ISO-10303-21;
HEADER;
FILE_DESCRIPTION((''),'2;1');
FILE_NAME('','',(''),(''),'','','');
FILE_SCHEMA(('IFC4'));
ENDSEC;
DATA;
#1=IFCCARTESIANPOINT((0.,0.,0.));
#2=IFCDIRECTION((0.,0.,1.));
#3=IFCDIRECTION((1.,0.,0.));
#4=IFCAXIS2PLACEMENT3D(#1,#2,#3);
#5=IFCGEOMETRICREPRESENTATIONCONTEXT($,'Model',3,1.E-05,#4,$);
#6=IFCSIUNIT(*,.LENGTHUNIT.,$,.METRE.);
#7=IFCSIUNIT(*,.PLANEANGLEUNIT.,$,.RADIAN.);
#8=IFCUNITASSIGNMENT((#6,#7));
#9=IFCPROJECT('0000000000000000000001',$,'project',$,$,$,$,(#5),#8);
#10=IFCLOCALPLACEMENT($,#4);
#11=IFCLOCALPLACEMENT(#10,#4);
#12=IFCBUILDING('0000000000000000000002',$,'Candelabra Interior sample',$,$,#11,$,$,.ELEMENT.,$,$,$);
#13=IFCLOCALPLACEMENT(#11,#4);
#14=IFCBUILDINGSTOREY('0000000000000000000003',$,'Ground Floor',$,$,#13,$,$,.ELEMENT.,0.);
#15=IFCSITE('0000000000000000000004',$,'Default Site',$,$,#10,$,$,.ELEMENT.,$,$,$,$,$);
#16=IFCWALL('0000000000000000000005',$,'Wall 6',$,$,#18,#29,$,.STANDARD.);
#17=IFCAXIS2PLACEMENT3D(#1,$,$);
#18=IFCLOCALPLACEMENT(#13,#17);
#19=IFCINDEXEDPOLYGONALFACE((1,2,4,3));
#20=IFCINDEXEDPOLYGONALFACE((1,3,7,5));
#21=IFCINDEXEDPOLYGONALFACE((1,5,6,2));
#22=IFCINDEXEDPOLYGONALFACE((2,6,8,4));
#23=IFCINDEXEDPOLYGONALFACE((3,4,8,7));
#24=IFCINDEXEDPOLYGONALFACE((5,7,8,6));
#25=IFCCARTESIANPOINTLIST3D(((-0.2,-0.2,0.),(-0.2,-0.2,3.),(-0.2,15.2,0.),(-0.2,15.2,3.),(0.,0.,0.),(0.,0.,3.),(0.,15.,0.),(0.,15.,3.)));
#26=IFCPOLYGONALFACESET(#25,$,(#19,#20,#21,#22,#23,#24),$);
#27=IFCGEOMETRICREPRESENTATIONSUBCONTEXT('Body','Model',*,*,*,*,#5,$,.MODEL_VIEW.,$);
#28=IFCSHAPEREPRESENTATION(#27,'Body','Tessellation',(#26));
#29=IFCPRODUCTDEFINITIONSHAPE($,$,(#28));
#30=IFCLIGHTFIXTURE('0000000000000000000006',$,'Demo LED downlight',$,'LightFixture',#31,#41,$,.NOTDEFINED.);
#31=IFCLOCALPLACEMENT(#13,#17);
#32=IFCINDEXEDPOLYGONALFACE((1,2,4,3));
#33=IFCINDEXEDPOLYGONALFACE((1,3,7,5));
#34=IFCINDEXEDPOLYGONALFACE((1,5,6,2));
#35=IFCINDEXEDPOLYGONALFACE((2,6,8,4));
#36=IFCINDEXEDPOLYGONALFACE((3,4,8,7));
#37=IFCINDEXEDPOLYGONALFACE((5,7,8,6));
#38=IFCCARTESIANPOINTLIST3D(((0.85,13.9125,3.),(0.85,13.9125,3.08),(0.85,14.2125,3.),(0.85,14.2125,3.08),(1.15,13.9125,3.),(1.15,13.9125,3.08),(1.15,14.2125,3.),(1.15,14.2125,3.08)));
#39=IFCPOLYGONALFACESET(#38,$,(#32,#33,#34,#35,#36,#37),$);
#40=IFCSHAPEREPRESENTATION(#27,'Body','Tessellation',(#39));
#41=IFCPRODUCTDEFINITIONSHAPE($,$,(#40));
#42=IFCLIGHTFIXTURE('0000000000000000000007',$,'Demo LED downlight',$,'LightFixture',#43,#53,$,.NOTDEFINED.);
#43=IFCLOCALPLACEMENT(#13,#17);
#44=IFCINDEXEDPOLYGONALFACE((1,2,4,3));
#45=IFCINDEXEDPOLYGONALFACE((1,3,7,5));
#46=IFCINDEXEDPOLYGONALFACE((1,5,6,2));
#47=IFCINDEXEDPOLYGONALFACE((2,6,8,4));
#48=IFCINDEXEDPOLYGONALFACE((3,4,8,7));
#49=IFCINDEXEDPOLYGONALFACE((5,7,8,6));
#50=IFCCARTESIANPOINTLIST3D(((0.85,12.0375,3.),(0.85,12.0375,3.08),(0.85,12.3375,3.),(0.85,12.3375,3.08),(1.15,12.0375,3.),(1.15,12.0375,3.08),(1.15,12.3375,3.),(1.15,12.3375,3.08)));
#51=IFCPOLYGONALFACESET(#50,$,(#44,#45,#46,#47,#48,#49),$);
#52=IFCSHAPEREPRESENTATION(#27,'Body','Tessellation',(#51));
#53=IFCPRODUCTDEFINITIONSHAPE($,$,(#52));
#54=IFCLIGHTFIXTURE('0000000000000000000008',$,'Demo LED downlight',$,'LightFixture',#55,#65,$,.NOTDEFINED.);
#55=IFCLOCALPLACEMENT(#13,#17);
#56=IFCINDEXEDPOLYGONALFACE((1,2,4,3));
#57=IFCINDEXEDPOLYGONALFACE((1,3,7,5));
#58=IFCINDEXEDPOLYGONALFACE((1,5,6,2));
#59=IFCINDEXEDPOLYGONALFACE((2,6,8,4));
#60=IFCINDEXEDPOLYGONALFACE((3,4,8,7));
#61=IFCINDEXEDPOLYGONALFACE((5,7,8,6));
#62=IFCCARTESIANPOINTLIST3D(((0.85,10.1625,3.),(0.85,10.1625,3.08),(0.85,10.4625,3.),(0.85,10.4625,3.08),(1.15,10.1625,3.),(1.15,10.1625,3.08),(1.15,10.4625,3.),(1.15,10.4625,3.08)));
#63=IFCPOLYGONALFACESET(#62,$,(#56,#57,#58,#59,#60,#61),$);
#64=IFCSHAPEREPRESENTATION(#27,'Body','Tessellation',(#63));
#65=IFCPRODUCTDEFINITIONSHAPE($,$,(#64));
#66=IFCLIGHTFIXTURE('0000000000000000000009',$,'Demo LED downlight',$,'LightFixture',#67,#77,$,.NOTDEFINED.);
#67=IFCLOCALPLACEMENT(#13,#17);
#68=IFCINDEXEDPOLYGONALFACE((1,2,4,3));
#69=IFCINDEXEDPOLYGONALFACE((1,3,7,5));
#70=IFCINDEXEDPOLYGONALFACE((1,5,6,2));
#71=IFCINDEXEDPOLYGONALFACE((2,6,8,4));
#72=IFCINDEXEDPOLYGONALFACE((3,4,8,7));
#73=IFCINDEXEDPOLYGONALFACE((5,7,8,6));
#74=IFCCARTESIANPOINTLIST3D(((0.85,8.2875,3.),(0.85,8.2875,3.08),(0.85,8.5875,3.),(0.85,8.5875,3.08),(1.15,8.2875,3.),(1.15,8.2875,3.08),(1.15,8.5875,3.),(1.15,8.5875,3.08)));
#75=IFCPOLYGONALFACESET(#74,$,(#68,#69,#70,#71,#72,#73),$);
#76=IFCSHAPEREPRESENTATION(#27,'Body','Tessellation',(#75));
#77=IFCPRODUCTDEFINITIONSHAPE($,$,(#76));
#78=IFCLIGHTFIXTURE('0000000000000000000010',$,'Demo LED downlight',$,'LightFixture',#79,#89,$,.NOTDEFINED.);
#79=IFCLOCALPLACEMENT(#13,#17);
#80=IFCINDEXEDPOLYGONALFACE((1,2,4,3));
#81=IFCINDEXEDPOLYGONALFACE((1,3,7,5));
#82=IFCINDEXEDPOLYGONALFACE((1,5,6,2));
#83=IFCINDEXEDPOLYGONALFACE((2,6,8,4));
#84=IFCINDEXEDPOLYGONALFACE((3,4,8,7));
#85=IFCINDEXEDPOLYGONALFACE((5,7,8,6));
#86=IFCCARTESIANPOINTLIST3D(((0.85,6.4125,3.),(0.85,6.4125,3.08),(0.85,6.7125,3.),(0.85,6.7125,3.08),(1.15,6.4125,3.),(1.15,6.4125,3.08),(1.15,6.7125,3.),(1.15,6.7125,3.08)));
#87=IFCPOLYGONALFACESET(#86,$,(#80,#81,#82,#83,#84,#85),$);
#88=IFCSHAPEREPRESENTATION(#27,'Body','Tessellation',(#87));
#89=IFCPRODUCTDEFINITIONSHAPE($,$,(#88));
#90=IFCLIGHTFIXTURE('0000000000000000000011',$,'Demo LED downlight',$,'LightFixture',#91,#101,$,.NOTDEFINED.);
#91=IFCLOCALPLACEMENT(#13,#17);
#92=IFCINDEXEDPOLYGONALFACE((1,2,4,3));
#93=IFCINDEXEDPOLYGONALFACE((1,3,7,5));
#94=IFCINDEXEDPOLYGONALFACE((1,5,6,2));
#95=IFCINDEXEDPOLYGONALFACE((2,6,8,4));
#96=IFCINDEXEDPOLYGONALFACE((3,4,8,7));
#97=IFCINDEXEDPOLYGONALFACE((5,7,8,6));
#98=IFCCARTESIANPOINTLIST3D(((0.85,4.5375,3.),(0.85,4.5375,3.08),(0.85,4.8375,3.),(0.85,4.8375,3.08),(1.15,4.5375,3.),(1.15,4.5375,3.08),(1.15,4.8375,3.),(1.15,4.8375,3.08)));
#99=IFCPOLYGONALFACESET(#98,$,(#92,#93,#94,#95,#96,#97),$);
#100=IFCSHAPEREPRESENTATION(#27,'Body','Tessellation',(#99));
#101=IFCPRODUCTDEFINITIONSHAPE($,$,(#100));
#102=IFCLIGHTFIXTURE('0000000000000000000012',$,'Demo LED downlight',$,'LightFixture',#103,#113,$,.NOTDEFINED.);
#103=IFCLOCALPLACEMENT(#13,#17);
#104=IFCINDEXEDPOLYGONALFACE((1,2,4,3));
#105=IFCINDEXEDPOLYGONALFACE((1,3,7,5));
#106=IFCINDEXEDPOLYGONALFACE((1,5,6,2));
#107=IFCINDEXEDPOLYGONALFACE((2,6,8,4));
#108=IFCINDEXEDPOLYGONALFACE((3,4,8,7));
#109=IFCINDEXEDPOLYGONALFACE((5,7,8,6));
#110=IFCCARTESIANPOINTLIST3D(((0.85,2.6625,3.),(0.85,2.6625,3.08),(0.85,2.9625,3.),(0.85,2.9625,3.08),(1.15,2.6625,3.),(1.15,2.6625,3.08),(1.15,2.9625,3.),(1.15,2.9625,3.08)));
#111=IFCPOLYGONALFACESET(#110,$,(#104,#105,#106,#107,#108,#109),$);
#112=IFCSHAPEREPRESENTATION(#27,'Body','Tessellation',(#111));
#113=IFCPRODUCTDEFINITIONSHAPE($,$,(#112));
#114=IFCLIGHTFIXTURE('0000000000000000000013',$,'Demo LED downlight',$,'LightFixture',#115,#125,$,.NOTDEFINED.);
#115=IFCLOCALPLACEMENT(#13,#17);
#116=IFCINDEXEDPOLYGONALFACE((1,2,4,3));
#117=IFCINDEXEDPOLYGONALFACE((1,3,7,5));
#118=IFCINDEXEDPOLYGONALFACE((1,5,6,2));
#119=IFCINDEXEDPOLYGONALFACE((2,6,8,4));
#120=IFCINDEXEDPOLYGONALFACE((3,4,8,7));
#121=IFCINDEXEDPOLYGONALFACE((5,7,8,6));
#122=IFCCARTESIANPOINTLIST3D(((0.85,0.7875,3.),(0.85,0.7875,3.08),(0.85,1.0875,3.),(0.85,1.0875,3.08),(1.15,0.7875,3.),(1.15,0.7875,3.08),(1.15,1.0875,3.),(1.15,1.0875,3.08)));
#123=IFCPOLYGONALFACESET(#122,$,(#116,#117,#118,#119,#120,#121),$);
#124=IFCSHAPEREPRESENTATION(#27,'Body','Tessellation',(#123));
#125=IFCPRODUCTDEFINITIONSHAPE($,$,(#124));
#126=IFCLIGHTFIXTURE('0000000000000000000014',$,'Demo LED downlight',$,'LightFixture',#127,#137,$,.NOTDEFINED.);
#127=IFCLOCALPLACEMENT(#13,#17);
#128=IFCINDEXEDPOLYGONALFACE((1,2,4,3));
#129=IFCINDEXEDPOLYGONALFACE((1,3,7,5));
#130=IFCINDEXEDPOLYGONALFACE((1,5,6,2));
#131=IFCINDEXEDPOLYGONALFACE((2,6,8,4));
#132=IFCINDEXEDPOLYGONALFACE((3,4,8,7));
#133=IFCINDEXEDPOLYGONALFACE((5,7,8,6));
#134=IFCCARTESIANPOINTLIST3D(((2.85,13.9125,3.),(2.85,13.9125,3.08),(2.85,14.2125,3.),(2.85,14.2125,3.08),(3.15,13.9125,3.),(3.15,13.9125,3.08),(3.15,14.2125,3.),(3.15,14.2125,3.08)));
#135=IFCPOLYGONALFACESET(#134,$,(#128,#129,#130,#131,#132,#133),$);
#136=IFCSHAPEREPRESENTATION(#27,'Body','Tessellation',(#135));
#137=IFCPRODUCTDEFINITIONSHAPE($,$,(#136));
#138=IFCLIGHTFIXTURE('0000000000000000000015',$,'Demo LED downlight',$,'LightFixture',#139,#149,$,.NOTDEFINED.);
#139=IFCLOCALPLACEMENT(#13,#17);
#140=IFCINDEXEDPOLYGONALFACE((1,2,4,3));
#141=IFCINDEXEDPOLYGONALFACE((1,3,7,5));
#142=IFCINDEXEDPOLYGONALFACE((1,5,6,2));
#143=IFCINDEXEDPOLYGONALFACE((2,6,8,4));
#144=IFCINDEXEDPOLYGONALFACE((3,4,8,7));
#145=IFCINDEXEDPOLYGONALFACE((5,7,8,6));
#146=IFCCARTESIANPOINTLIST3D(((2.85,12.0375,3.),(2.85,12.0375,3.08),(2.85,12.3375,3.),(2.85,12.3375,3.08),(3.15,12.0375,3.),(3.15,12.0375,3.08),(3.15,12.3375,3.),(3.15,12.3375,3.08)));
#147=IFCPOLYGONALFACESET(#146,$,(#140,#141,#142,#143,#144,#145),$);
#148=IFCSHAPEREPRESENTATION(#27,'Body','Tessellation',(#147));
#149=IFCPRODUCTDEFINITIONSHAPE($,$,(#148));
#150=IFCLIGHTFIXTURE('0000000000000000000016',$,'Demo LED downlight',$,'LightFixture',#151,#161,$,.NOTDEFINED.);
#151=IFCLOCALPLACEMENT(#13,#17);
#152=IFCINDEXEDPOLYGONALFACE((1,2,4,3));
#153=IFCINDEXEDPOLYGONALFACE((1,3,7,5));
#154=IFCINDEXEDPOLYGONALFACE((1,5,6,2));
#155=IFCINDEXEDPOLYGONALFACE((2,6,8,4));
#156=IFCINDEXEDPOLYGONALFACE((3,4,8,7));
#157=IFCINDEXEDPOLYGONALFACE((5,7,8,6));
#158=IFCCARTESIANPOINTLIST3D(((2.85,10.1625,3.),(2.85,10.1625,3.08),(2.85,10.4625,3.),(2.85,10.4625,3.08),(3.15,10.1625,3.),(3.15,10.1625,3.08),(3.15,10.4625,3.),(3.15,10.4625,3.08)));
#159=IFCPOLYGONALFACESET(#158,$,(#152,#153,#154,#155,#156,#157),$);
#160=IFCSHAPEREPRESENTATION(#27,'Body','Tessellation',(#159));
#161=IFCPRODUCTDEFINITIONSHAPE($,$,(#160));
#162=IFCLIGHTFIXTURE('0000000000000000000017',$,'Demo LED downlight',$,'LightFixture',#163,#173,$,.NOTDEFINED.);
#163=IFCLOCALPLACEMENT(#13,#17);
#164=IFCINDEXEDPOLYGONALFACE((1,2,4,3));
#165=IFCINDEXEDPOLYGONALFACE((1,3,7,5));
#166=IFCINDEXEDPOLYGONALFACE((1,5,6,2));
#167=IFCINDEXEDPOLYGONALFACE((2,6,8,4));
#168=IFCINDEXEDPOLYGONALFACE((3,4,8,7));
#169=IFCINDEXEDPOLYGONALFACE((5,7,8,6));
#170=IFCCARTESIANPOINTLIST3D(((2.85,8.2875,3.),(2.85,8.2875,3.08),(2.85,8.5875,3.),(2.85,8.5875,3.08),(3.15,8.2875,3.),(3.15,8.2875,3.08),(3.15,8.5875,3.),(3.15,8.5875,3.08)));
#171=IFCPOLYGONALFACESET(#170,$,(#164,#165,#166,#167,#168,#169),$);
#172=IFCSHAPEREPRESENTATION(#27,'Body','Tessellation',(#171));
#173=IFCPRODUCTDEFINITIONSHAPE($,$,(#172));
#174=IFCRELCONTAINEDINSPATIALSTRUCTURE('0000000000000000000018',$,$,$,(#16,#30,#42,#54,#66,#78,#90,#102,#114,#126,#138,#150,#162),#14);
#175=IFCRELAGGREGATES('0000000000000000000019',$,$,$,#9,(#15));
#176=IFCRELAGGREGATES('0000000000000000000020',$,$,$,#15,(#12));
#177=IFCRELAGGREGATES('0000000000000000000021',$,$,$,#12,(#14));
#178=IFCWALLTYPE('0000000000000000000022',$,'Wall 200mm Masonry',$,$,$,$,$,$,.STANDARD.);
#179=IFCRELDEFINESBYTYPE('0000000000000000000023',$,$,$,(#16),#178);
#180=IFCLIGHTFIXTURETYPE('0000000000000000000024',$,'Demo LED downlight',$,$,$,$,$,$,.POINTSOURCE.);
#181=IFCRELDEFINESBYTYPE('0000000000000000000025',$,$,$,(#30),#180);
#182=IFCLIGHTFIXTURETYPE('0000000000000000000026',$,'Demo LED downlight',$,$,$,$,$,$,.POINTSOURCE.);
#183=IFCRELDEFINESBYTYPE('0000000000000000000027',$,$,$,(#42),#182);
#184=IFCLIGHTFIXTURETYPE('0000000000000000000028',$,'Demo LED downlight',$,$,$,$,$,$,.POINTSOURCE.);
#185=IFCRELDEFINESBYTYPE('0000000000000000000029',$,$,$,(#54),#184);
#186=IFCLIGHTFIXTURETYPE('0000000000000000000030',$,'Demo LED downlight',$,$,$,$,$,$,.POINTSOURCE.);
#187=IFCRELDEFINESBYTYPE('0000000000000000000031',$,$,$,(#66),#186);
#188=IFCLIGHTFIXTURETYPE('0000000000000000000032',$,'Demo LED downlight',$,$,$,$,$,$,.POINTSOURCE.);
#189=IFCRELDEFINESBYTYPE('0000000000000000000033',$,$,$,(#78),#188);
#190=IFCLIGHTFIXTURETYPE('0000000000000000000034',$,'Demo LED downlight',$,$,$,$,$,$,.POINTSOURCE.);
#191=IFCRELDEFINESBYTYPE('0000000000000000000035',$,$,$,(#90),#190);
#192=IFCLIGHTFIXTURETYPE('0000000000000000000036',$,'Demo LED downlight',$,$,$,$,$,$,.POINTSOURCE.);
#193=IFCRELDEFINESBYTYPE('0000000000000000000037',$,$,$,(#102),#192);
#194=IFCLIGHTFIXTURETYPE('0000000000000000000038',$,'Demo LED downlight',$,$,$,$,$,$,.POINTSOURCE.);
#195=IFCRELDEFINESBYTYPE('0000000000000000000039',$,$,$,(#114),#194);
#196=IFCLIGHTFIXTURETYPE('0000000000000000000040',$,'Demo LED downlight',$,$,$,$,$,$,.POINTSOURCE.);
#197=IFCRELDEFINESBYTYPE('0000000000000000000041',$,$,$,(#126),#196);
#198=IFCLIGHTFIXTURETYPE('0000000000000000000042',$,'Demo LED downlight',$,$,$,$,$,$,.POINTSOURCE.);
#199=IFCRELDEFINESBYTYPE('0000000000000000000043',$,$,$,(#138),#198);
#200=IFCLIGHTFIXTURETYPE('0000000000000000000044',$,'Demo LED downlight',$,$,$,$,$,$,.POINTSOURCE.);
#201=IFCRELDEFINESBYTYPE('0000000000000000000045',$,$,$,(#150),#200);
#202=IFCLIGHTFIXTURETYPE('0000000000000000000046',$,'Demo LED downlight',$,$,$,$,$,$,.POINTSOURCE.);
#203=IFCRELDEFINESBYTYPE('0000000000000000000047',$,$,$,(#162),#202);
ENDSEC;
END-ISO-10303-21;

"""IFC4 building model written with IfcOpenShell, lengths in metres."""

from ifc_helpers import new_model, si_unit, frame, origin_with_axes, place, context, subcontext, project, spatial, polyline, outline, extrude, type_object, element, save


model = new_model("IFC4")

# Units and contexts
model_context = context("Model", 3, precision=1e-05, world=origin_with_axes())
body_context = subcontext(model_context, "Body", "Model", "MODEL_VIEW")
ifc_project = project(units=[si_unit("LENGTHUNIT", "METRE"), si_unit("PLANEANGLEUNIT", "RADIAN")], contexts=[model_context])

# Site, building, storey
site_placement = place(None, origin_with_axes())
site = spatial("IfcSite", under=ifc_project, at=site_placement, Name="Default Site", CompositionType="ELEMENT")
building_placement = place(site_placement, origin_with_axes())
building = spatial("IfcBuilding", under=site, at=building_placement, Name="Candelabra Interior sample", CompositionType="ELEMENT")
storey_placement = place(building_placement, origin_with_axes())
storey = spatial("IfcBuildingStorey", under=building, at=storey_placement, Name="Ground Floor", CompositionType="ELEMENT", Elevation=0.0)

# Wall
wall_type = type_object("IfcWallType", Name="Wall 200mm Masonry", PredefinedType="STANDARD")
wall_placement = place(storey_placement, frame((-0.1, 7.5, 0.0), z_axis=(0.0, 0.0, 1.0), x_axis=(0.0, -1.0, 0.0)))
element("IfcWall", 1, at=wall_placement, inside=storey, type_object=wall_type, Name="Wall 6", PredefinedType="STANDARD", context=body_context, shape_type="SweptSolid", body=[
    extrude(outline(polyline([(7.5, 0.1), (-7.5, 0.1), (-7.7, -0.1), (7.7, -0.1), (7.5, 0.1)])), origin_with_axes(), (0.0, 0.0, 1.0), 3.0),
])

# Light fixtures
light_fixture_type_1 = type_object("IfcLightFixtureType", Name="Demo LED downlight", PredefinedType="POINTSOURCE")
light_fixture_1_placement = place(storey_placement, frame((1.0, 14.0625, 3.08), z_axis=(0.0, 0.0, 1.0), x_axis=(1.0, 0.0, 0.0)))
element("IfcLightFixture", 2, at=light_fixture_1_placement, inside=storey, type_object=light_fixture_type_1, Name="Demo LED downlight", ObjectType="LightFixture", PredefinedType="NOTDEFINED", context=body_context, shape_type="SweptSolid", body=[
    extrude(outline(polyline([(0.15, 0.15), (-0.15, 0.15), (-0.15, -0.15), (0.15, -0.15), (0.15, 0.15)])), origin_with_axes(), (0.0, 0.0, -1.0), 0.08),
])
light_fixture_type_2 = type_object("IfcLightFixtureType", Name="Demo LED downlight", PredefinedType="POINTSOURCE")
light_fixture_2_placement = place(storey_placement, frame((1.0, 12.1875, 3.08), z_axis=(0.0, 0.0, 1.0), x_axis=(1.0, 0.0, 0.0)))
element("IfcLightFixture", 3, at=light_fixture_2_placement, inside=storey, type_object=light_fixture_type_2, Name="Demo LED downlight", ObjectType="LightFixture", PredefinedType="NOTDEFINED", context=body_context, shape_type="SweptSolid", body=[
    extrude(outline(polyline([(0.15, 0.15), (-0.15, 0.15), (-0.15, -0.15), (0.15, -0.15), (0.15, 0.15)])), origin_with_axes(), (0.0, 0.0, -1.0), 0.08),
])
light_fixture_type_3 = type_object("IfcLightFixtureType", Name="Demo LED downlight", PredefinedType="POINTSOURCE")
light_fixture_3_placement = place(storey_placement, frame((1.0, 10.3125, 3.08), z_axis=(0.0, 0.0, 1.0), x_axis=(1.0, 0.0, 0.0)))
element("IfcLightFixture", 4, at=light_fixture_3_placement, inside=storey, type_object=light_fixture_type_3, Name="Demo LED downlight", ObjectType="LightFixture", PredefinedType="NOTDEFINED", context=body_context, shape_type="SweptSolid", body=[
    extrude(outline(polyline([(0.15, 0.15), (-0.15, 0.15), (-0.15, -0.15), (0.15, -0.15), (0.15, 0.15)])), origin_with_axes(), (0.0, 0.0, -1.0), 0.08),
])
light_fixture_type_4 = type_object("IfcLightFixtureType", Name="Demo LED downlight", PredefinedType="POINTSOURCE")
light_fixture_4_placement = place(storey_placement, frame((1.0, 8.4375, 3.08), z_axis=(0.0, 0.0, 1.0), x_axis=(1.0, 0.0, 0.0)))
element("IfcLightFixture", 5, at=light_fixture_4_placement, inside=storey, type_object=light_fixture_type_4, Name="Demo LED downlight", ObjectType="LightFixture", PredefinedType="NOTDEFINED", context=body_context, shape_type="SweptSolid", body=[
    extrude(outline(polyline([(0.15, 0.15), (-0.15, 0.15), (-0.15, -0.15), (0.15, -0.15), (0.15, 0.15)])), origin_with_axes(), (0.0, 0.0, -1.0), 0.08),
])
light_fixture_type_5 = type_object("IfcLightFixtureType", Name="Demo LED downlight", PredefinedType="POINTSOURCE")
light_fixture_5_placement = place(storey_placement, frame((1.0, 6.5625, 3.08), z_axis=(0.0, 0.0, 1.0), x_axis=(1.0, 0.0, 0.0)))
element("IfcLightFixture", 6, at=light_fixture_5_placement, inside=storey, type_object=light_fixture_type_5, Name="Demo LED downlight", ObjectType="LightFixture", PredefinedType="NOTDEFINED", context=body_context, shape_type="SweptSolid", body=[
    extrude(outline(polyline([(0.15, 0.15), (-0.15, 0.15), (-0.15, -0.15), (0.15, -0.15), (0.15, 0.15)])), origin_with_axes(), (0.0, 0.0, -1.0), 0.08),
])
light_fixture_type_6 = type_object("IfcLightFixtureType", Name="Demo LED downlight", PredefinedType="POINTSOURCE")
light_fixture_6_placement = place(storey_placement, frame((1.0, 4.6875, 3.08), z_axis=(0.0, 0.0, 1.0), x_axis=(1.0, 0.0, 0.0)))
element("IfcLightFixture", 7, at=light_fixture_6_placement, inside=storey, type_object=light_fixture_type_6, Name="Demo LED downlight", ObjectType="LightFixture", PredefinedType="NOTDEFINED", context=body_context, shape_type="SweptSolid", body=[
    extrude(outline(polyline([(0.15, 0.15), (-0.15, 0.15), (-0.15, -0.15), (0.15, -0.15), (0.15, 0.15)])), origin_with_axes(), (0.0, 0.0, -1.0), 0.08),
])
light_fixture_type_7 = type_object("IfcLightFixtureType", Name="Demo LED downlight", PredefinedType="POINTSOURCE")
light_fixture_7_placement = place(storey_placement, frame((1.0, 2.8125, 3.08), z_axis=(0.0, 0.0, 1.0), x_axis=(1.0, 0.0, 0.0)))
element("IfcLightFixture", 8, at=light_fixture_7_placement, inside=storey, type_object=light_fixture_type_7, Name="Demo LED downlight", ObjectType="LightFixture", PredefinedType="NOTDEFINED", context=body_context, shape_type="SweptSolid", body=[
    extrude(outline(polyline([(0.15, 0.15), (-0.15, 0.15), (-0.15, -0.15), (0.15, -0.15), (0.15, 0.15)])), origin_with_axes(), (0.0, 0.0, -1.0), 0.08),
])
light_fixture_type_8 = type_object("IfcLightFixtureType", Name="Demo LED downlight", PredefinedType="POINTSOURCE")
light_fixture_8_placement = place(storey_placement, frame((1.0, 0.9375, 3.08), z_axis=(0.0, 0.0, 1.0), x_axis=(1.0, 0.0, 0.0)))
element("IfcLightFixture", 9, at=light_fixture_8_placement, inside=storey, type_object=light_fixture_type_8, Name="Demo LED downlight", ObjectType="LightFixture", PredefinedType="NOTDEFINED", context=body_context, shape_type="SweptSolid", body=[
    extrude(outline(polyline([(0.15, 0.15), (-0.15, 0.15), (-0.15, -0.15), (0.15, -0.15), (0.15, 0.15)])), origin_with_axes(), (0.0, 0.0, -1.0), 0.08),
])
light_fixture_type_9 = type_object("IfcLightFixtureType", Name="Demo LED downlight", PredefinedType="POINTSOURCE")
light_fixture_9_placement = place(storey_placement, frame((3.0, 14.0625, 3.08), z_axis=(0.0, 0.0, 1.0), x_axis=(1.0, 0.0, 0.0)))
element("IfcLightFixture", 10, at=light_fixture_9_placement, inside=storey, type_object=light_fixture_type_9, Name="Demo LED downlight", ObjectType="LightFixture", PredefinedType="NOTDEFINED", context=body_context, shape_type="SweptSolid", body=[
    extrude(outline(polyline([(0.15, 0.15), (-0.15, 0.15), (-0.15, -0.15), (0.15, -0.15), (0.15, 0.15)])), origin_with_axes(), (0.0, 0.0, -1.0), 0.08),
])
light_fixture_type_10 = type_object("IfcLightFixtureType", Name="Demo LED downlight", PredefinedType="POINTSOURCE")
light_fixture_10_placement = place(storey_placement, frame((3.0, 12.1875, 3.08), z_axis=(0.0, 0.0, 1.0), x_axis=(1.0, 0.0, 0.0)))
element("IfcLightFixture", 11, at=light_fixture_10_placement, inside=storey, type_object=light_fixture_type_10, Name="Demo LED downlight", ObjectType="LightFixture", PredefinedType="NOTDEFINED", context=body_context, shape_type="SweptSolid", body=[
    extrude(outline(polyline([(0.15, 0.15), (-0.15, 0.15), (-0.15, -0.15), (0.15, -0.15), (0.15, 0.15)])), origin_with_axes(), (0.0, 0.0, -1.0), 0.08),
])
light_fixture_type_11 = type_object("IfcLightFixtureType", Name="Demo LED downlight", PredefinedType="POINTSOURCE")
light_fixture_11_placement = place(storey_placement, frame((3.0, 10.3125, 3.08), z_axis=(0.0, 0.0, 1.0), x_axis=(1.0, 0.0, 0.0)))
element("IfcLightFixture", 12, at=light_fixture_11_placement, inside=storey, type_object=light_fixture_type_11, Name="Demo LED downlight", ObjectType="LightFixture", PredefinedType="NOTDEFINED", context=body_context, shape_type="SweptSolid", body=[
    extrude(outline(polyline([(0.15, 0.15), (-0.15, 0.15), (-0.15, -0.15), (0.15, -0.15), (0.15, 0.15)])), origin_with_axes(), (0.0, 0.0, -1.0), 0.08),
])
light_fixture_type_12 = type_object("IfcLightFixtureType", Name="Demo LED downlight", PredefinedType="POINTSOURCE")
light_fixture_12_placement = place(storey_placement, frame((3.0, 8.4375, 3.08), z_axis=(0.0, 0.0, 1.0), x_axis=(1.0, 0.0, 0.0)))
element("IfcLightFixture", 13, at=light_fixture_12_placement, inside=storey, type_object=light_fixture_type_12, Name="Demo LED downlight", ObjectType="LightFixture", PredefinedType="NOTDEFINED", context=body_context, shape_type="SweptSolid", body=[
    extrude(outline(polyline([(0.15, 0.15), (-0.15, 0.15), (-0.15, -0.15), (0.15, -0.15), (0.15, 0.15)])), origin_with_axes(), (0.0, 0.0, -1.0), 0.08),
])

save(model, "model.ifc")
